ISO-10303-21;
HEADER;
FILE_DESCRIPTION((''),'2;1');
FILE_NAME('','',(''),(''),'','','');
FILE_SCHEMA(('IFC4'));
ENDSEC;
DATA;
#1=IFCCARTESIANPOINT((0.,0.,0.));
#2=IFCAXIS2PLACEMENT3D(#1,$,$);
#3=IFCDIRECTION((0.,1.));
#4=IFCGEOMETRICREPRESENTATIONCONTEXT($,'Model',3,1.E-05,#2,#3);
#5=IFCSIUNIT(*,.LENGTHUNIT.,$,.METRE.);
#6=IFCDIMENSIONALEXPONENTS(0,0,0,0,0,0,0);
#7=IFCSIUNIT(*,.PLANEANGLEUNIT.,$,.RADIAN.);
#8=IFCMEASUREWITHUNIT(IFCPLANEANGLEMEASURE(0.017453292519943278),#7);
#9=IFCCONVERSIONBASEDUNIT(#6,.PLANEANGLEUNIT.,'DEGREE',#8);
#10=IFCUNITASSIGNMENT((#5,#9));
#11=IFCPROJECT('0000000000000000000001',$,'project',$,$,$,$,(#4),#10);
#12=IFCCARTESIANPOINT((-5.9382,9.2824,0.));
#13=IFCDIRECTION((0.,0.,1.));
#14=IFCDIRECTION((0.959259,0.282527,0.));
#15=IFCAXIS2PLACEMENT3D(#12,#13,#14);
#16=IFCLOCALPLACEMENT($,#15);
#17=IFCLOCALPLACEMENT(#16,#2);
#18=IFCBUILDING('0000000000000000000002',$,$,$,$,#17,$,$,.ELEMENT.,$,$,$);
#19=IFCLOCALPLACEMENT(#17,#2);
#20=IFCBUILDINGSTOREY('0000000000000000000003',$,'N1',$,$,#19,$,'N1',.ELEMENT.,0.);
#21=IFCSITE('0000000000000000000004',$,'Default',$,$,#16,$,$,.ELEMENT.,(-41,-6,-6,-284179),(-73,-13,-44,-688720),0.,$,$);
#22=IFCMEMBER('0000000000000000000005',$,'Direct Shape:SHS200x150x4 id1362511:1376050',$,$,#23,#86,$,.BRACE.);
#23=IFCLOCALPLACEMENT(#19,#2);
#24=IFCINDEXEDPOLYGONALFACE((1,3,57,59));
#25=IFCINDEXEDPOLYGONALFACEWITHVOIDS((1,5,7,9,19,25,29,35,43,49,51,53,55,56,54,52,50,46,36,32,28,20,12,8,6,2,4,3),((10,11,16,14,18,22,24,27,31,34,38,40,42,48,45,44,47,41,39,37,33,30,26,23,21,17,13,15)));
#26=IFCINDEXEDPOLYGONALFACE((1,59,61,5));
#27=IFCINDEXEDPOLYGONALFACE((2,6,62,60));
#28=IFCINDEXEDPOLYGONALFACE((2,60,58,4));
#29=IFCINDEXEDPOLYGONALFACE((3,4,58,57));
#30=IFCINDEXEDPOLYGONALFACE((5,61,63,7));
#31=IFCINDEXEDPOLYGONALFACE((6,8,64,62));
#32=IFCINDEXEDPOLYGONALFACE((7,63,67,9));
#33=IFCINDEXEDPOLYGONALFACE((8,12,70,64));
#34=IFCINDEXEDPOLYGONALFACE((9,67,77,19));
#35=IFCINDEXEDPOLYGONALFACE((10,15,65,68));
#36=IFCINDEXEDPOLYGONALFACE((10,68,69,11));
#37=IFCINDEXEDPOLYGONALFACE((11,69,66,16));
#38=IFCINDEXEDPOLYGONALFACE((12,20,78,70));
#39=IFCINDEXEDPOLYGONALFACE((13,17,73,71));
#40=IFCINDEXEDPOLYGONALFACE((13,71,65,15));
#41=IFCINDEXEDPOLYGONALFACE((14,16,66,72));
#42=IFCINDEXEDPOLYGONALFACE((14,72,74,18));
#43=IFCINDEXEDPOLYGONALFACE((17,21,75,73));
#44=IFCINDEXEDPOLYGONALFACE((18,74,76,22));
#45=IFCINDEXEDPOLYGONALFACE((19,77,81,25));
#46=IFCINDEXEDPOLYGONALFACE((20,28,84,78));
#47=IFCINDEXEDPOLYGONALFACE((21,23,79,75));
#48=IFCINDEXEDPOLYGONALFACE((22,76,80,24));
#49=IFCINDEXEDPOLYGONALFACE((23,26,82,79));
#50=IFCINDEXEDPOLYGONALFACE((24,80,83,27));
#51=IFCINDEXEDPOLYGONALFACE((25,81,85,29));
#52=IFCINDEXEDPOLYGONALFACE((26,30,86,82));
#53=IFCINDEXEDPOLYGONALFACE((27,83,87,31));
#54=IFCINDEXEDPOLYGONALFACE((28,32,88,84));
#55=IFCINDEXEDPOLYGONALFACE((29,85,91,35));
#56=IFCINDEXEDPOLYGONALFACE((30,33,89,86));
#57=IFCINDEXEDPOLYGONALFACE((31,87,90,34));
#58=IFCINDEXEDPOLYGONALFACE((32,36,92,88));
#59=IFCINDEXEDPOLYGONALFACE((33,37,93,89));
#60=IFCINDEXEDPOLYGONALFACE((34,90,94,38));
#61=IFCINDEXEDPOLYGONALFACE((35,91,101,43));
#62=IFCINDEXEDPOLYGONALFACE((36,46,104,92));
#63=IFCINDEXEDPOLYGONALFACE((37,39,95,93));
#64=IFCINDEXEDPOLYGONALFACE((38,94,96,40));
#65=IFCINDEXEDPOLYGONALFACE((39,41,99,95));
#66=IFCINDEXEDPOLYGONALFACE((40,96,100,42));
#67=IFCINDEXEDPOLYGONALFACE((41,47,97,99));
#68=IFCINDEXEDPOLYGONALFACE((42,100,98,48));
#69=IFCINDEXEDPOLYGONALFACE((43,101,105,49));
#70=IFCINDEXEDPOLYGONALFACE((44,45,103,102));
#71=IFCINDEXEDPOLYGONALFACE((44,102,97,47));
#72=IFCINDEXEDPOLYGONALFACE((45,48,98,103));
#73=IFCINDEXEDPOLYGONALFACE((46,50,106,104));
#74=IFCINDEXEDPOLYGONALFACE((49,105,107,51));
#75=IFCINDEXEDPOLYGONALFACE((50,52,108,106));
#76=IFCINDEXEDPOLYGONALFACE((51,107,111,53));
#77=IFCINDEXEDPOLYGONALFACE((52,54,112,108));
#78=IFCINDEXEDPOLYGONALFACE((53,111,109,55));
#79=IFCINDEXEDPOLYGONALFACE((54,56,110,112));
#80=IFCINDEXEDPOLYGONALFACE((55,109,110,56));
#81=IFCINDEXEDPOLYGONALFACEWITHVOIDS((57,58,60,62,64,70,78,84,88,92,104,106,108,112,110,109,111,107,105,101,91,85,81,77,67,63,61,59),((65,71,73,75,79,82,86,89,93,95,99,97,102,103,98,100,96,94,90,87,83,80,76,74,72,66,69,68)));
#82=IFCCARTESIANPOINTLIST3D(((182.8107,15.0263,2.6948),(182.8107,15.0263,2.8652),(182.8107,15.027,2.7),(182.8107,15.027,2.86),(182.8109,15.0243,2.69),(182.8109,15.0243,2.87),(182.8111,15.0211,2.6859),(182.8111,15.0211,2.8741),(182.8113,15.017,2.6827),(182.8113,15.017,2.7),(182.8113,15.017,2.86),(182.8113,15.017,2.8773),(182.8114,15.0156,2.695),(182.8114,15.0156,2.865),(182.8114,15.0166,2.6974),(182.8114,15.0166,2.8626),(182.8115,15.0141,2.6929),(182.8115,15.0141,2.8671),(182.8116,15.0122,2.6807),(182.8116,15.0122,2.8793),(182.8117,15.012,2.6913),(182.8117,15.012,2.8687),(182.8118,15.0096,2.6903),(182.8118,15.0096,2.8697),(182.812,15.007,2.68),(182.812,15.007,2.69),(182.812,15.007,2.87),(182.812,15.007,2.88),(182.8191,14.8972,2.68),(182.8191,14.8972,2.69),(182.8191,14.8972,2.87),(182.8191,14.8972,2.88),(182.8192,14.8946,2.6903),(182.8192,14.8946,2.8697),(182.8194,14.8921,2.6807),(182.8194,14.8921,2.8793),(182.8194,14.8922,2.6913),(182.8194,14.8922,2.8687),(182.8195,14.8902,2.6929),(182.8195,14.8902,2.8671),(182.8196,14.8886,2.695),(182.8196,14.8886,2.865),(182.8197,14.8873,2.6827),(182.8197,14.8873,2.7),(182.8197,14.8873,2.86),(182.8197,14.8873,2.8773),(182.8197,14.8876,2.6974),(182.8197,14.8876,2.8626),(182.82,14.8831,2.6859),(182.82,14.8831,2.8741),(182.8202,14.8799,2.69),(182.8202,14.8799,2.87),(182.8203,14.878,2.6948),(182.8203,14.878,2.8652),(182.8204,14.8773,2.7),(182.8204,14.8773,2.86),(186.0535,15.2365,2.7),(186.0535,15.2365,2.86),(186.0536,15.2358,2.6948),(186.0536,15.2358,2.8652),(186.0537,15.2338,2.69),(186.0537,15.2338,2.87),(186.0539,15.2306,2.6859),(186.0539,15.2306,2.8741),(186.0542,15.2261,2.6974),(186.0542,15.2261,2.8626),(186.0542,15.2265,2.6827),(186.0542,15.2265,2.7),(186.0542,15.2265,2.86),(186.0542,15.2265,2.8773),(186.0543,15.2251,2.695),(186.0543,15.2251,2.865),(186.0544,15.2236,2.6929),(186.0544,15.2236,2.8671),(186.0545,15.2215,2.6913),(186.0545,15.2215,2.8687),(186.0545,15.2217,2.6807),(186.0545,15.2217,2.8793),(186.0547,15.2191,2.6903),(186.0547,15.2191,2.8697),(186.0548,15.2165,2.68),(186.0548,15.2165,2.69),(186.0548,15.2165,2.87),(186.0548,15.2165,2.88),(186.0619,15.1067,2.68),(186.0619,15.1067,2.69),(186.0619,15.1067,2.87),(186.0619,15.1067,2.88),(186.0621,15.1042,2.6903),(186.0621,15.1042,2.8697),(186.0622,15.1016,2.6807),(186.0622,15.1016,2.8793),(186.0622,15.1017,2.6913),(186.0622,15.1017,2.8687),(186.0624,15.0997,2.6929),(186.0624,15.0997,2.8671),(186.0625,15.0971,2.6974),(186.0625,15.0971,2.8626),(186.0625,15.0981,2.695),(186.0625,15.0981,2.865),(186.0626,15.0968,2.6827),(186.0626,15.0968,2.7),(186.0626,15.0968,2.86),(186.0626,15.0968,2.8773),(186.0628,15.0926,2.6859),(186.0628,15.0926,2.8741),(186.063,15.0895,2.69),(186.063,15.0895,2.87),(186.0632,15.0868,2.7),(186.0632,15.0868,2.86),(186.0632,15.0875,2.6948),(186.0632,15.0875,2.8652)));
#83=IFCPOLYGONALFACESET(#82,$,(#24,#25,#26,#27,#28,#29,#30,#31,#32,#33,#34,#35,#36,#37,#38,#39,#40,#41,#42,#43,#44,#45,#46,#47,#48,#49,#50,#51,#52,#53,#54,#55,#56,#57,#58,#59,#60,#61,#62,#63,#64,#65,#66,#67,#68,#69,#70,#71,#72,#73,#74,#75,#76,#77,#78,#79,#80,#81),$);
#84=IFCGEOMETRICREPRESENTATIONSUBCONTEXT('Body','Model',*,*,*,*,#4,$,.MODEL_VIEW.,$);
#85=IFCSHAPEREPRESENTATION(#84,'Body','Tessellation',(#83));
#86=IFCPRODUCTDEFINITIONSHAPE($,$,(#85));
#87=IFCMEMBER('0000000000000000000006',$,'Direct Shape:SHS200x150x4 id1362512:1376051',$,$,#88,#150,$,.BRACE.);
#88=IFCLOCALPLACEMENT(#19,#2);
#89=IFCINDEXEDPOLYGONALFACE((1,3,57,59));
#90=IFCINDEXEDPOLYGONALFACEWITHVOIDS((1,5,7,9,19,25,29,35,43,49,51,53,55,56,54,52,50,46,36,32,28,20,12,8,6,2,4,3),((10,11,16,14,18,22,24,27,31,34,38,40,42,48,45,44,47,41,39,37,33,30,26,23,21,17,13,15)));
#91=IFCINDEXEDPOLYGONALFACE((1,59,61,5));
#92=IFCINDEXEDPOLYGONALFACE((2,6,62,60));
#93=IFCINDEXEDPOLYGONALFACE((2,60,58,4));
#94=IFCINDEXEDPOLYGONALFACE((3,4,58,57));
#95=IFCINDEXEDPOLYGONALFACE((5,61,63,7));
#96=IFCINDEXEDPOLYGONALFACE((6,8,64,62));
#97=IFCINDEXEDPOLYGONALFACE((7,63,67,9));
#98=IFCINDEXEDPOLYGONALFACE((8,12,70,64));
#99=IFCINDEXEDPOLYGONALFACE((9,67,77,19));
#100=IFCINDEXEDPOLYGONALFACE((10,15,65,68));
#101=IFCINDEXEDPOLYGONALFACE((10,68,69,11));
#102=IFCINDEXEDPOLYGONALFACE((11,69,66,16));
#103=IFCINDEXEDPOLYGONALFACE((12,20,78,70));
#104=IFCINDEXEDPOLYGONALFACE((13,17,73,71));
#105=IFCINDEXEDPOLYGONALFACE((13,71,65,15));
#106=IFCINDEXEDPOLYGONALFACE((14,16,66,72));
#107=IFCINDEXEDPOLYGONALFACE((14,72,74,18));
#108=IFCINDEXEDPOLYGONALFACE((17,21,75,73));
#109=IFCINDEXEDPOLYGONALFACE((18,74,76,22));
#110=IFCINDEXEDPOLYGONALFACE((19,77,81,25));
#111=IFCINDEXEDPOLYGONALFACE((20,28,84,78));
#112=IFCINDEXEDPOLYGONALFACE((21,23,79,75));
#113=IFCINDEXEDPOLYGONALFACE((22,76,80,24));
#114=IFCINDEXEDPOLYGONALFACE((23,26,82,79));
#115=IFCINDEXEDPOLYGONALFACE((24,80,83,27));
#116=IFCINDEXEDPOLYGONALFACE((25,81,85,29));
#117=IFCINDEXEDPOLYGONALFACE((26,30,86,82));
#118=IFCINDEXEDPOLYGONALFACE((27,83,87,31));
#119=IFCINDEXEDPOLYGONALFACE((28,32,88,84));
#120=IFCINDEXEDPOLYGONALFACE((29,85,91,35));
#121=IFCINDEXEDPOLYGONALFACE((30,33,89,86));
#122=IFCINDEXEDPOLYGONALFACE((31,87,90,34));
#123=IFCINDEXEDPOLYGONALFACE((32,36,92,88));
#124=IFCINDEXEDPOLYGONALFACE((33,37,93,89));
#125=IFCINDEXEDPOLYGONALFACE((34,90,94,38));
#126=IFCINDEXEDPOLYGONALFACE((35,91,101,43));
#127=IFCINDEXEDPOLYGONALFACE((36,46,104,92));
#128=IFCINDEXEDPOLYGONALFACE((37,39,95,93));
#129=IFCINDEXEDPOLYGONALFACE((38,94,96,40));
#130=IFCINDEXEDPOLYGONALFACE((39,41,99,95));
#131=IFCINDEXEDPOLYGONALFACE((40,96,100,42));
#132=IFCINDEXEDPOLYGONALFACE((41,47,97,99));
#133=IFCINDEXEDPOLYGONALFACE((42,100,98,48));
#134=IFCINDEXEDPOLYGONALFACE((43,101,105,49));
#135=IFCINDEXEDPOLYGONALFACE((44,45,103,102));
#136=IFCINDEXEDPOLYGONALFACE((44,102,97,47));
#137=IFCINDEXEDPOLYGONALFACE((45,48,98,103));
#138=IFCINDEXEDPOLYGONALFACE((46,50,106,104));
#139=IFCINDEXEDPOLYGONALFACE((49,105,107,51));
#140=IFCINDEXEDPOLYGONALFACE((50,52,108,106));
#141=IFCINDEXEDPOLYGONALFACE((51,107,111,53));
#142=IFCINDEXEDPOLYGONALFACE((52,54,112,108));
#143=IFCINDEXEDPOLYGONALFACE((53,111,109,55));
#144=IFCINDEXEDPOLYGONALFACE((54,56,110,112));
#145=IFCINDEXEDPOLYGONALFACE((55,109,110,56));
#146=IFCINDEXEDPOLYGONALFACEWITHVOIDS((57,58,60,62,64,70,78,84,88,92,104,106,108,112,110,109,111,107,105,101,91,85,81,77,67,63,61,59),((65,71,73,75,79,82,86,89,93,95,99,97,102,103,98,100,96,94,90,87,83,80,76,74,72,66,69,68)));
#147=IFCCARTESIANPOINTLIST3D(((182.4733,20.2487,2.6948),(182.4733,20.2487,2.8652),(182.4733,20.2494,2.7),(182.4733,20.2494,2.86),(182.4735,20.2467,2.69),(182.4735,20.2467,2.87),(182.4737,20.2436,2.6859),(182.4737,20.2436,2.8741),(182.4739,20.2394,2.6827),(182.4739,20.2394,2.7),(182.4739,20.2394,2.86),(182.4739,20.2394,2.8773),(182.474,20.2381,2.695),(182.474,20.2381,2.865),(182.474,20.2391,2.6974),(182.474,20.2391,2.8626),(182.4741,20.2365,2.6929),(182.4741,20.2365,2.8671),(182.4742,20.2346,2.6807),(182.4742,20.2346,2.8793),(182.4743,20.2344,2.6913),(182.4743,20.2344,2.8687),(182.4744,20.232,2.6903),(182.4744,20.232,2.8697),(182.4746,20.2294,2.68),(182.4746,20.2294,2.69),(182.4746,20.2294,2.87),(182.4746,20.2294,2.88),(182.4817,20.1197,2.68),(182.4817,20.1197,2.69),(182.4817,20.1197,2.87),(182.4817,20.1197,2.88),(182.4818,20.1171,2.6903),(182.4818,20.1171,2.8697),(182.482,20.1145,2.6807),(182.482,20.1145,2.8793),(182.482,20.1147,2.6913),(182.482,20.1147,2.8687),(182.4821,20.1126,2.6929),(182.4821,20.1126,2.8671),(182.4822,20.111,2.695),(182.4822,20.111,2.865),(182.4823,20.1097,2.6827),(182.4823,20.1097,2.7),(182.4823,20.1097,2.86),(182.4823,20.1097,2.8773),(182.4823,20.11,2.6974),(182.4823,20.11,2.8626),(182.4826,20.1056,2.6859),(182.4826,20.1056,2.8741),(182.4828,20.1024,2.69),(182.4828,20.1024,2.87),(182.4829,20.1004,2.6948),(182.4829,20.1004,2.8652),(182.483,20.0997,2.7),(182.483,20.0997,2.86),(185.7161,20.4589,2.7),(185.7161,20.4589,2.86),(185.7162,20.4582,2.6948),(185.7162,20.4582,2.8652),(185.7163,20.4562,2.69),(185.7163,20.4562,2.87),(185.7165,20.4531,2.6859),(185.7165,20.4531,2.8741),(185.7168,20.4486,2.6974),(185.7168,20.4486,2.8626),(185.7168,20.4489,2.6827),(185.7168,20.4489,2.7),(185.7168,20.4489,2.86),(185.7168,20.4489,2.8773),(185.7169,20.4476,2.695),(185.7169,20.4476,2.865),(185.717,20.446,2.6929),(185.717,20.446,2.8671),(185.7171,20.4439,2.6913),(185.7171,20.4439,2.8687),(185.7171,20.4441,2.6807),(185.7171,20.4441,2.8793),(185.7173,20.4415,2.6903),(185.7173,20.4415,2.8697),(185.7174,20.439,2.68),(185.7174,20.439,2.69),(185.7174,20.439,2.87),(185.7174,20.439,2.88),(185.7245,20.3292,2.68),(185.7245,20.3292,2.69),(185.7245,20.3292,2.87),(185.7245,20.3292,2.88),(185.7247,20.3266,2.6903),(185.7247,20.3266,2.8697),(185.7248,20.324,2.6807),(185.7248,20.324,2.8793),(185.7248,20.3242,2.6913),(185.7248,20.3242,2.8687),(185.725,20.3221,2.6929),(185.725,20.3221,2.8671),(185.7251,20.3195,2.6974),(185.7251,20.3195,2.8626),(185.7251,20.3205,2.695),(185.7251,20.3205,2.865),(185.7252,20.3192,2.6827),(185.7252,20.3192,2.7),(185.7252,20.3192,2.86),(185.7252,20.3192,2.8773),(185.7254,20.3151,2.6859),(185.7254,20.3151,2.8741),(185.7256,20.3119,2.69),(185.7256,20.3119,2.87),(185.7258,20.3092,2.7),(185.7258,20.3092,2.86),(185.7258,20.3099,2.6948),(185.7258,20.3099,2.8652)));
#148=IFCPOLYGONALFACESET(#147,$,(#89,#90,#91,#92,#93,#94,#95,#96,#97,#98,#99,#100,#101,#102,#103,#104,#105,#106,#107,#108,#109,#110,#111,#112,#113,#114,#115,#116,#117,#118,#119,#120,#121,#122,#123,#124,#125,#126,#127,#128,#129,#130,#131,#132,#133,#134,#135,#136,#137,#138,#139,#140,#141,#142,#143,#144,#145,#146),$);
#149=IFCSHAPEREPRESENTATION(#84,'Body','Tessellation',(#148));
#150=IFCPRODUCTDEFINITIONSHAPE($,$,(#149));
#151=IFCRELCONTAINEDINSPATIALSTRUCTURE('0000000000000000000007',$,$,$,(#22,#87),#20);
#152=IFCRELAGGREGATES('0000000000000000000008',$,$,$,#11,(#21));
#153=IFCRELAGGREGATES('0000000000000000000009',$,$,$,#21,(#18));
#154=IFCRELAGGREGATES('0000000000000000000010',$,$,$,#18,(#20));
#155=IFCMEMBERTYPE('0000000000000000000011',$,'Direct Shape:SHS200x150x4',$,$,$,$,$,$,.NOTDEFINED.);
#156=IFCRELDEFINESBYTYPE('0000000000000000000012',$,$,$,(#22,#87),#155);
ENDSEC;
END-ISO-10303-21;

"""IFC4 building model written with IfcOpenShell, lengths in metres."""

from ifc_helpers import new_model, entity, si_unit, converted_unit, direction, frame, frame_2d, origin, place, context, subcontext, project, spatial, polyline, circle_curve, parameter, trimmed, segment, composite_curve, outline, extrude, type_object, element, save


model = new_model("IFC4")

# Units and contexts
model_context = context("Model", 3, precision=1e-05, world=origin(), true_north=direction((0.0, 1.0)))
body_context = subcontext(model_context, "Body", "Model", "MODEL_VIEW")
ifc_project = project(units=[si_unit("LENGTHUNIT", "METRE"), converted_unit("PLANEANGLEUNIT", "DEGREE", entity("IfcPlaneAngleMeasure", 0.017453292519943278), si_unit("PLANEANGLEUNIT", "RADIAN"), dimensions=[0, 0, 0, 0, 0, 0, 0])], contexts=[model_context])

# Site, building, storey
site_placement = place(None, frame((-5.9382, 9.2824, 0.0), z_axis=(0.0, 0.0, 1.0), x_axis=(0.959259, 0.282527, 0.0)))
site = spatial("IfcSite", under=ifc_project, at=site_placement, Name="Default", CompositionType="ELEMENT", RefLatitude=(-41, -6, -6, -284179), RefLongitude=(-73, -13, -44, -688720), RefElevation=0.0)
building_placement = place(site_placement, origin())
building = spatial("IfcBuilding", under=site, at=building_placement, CompositionType="ELEMENT")
storey_placement = place(building_placement, origin())
storey = spatial("IfcBuildingStorey", under=building, at=storey_placement, Name="N1", LongName="N1", CompositionType="ELEMENT", Elevation=0.0)

# Members
member_type_1 = type_object("IfcMemberType", Name="Direct Shape:SHS200x150x4", PredefinedType="NOTDEFINED")
member_1_placement = place(storey_placement, origin())
element("IfcMember", 1, at=member_1_placement, inside=storey, type_object=member_type_1, Name="Direct Shape:SHS200x150x4 id1362511:1376050", PredefinedType="BRACE", context=body_context, shape_type="SweptSolid", body=[
    extrude(outline(composite_curve([segment(polyline([(-0.08, -0.075), (0.08, -0.075)]), True, "CONTINUOUS"), segment(trimmed(circle_curve(frame_2d((0.08, -0.055), x_axis=(0.0, 1.0)), 0.02), [parameter(180.0)], [parameter(270.0)], True, "PARAMETER"), True, "CONTINUOUS"), segment(polyline([(0.1, -0.055), (0.1, 0.055)]), True, "CONTINUOUS"), segment(trimmed(circle_curve(frame_2d((0.08, 0.055), x_axis=(0.0, 1.0)), 0.02), [parameter(270.0)], [parameter(0.0)], True, "PARAMETER"), True, "CONTINUOUS"), segment(polyline([(0.08, 0.075), (-0.08, 0.075)]), True, "CONTINUOUS"), segment(trimmed(circle_curve(frame_2d((-0.08, 0.055), x_axis=(0.0, 1.0)), 0.02), [parameter(360.0)], [parameter(90.0)], True, "PARAMETER"), True, "CONTINUOUS"), segment(polyline([(-0.1, 0.055), (-0.1, -0.055)]), True, "CONTINUOUS"), segment(trimmed(circle_curve(frame_2d((-0.08, -0.055), x_axis=(0.0, 1.0)), 0.02), [parameter(90.0)], [parameter(180.0)], True, "PARAMETER"), True, "CONTINUOUS")], self_intersect=False), holes=[composite_curve([segment(trimmed(circle_curve(frame_2d((-0.08, 0.055), x_axis=(0.0, 1.0)), 0.01), [parameter(360.0)], [parameter(90.0)], True, "PARAMETER"), False, "CONTINUOUS"), segment(polyline([(-0.08, 0.065), (0.08, 0.065)]), True, "CONTINUOUS"), segment(trimmed(circle_curve(frame_2d((0.08, 0.055), x_axis=(0.0, 1.0)), 0.01), [parameter(270.0)], [parameter(0.0)], True, "PARAMETER"), False, "CONTINUOUS"), segment(polyline([(0.09, 0.055), (0.09, -0.055)]), True, "CONTINUOUS"), segment(trimmed(circle_curve(frame_2d((0.08, -0.055), x_axis=(0.0, 1.0)), 0.01), [parameter(180.0)], [parameter(270.0)], True, "PARAMETER"), False, "CONTINUOUS"), segment(polyline([(0.08, -0.065), (-0.08, -0.065)]), True, "CONTINUOUS"), segment(trimmed(circle_curve(frame_2d((-0.08, -0.055), x_axis=(0.0, 1.0)), 0.01), [parameter(90.0)], [parameter(180.0)], True, "PARAMETER"), False, "CONTINUOUS"), segment(polyline([(-0.09, -0.055), (-0.09, 0.055)]), True, "CONTINUOUS")], self_intersect=False)]), frame((182.8155, 14.9521, 2.78), z_axis=(0.99792, 0.064471, 0.0), x_axis=(0.0, 0.0, -1.0)), (0.0, 0.0, 1.0), 3.2496),
])
member_2_placement = place(storey_placement, origin())
element("IfcMember", 2, at=member_2_placement, inside=storey, type_object=member_type_1, Name="Direct Shape:SHS200x150x4 id1362512:1376051", PredefinedType="BRACE", context=body_context, shape_type="SweptSolid", body=[
    extrude(outline(composite_curve([segment(polyline([(-0.08, -0.075), (0.08, -0.075)]), True, "CONTINUOUS"), segment(trimmed(circle_curve(frame_2d((0.08, -0.055), x_axis=(0.0, 1.0)), 0.02), [parameter(180.0)], [parameter(270.0)], True, "PARAMETER"), True, "CONTINUOUS"), segment(polyline([(0.1, -0.055), (0.1, 0.055)]), True, "CONTINUOUS"), segment(trimmed(circle_curve(frame_2d((0.08, 0.055), x_axis=(0.0, 1.0)), 0.02), [parameter(270.0)], [parameter(0.0)], True, "PARAMETER"), True, "CONTINUOUS"), segment(polyline([(0.08, 0.075), (-0.08, 0.075)]), True, "CONTINUOUS"), segment(trimmed(circle_curve(frame_2d((-0.08, 0.055), x_axis=(0.0, 1.0)), 0.02), [parameter(360.0)], [parameter(90.0)], True, "PARAMETER"), True, "CONTINUOUS"), segment(polyline([(-0.1, 0.055), (-0.1, -0.055)]), True, "CONTINUOUS"), segment(trimmed(circle_curve(frame_2d((-0.08, -0.055), x_axis=(0.0, 1.0)), 0.02), [parameter(90.0)], [parameter(180.0)], True, "PARAMETER"), True, "CONTINUOUS")], self_intersect=False), holes=[composite_curve([segment(trimmed(circle_curve(frame_2d((-0.08, 0.055), x_axis=(0.0, 1.0)), 0.01), [parameter(360.0)], [parameter(90.0)], True, "PARAMETER"), False, "CONTINUOUS"), segment(polyline([(-0.08, 0.065), (0.08, 0.065)]), True, "CONTINUOUS"), segment(trimmed(circle_curve(frame_2d((0.08, 0.055), x_axis=(0.0, 1.0)), 0.01), [parameter(270.0)], [parameter(0.0)], True, "PARAMETER"), False, "CONTINUOUS"), segment(polyline([(0.09, 0.055), (0.09, -0.055)]), True, "CONTINUOUS"), segment(trimmed(circle_curve(frame_2d((0.08, -0.055), x_axis=(0.0, 1.0)), 0.01), [parameter(180.0)], [parameter(270.0)], True, "PARAMETER"), False, "CONTINUOUS"), segment(polyline([(0.08, -0.065), (-0.08, -0.065)]), True, "CONTINUOUS"), segment(trimmed(circle_curve(frame_2d((-0.08, -0.055), x_axis=(0.0, 1.0)), 0.01), [parameter(90.0)], [parameter(180.0)], True, "PARAMETER"), False, "CONTINUOUS"), segment(polyline([(-0.09, -0.055), (-0.09, 0.055)]), True, "CONTINUOUS")], self_intersect=False)]), frame((182.4781, 20.1746, 2.78), z_axis=(0.99792, 0.064471, 0.0), x_axis=(0.0, 0.0, -1.0)), (0.0, 0.0, 1.0), 3.2496),
])

save(model, "model.ifc")
